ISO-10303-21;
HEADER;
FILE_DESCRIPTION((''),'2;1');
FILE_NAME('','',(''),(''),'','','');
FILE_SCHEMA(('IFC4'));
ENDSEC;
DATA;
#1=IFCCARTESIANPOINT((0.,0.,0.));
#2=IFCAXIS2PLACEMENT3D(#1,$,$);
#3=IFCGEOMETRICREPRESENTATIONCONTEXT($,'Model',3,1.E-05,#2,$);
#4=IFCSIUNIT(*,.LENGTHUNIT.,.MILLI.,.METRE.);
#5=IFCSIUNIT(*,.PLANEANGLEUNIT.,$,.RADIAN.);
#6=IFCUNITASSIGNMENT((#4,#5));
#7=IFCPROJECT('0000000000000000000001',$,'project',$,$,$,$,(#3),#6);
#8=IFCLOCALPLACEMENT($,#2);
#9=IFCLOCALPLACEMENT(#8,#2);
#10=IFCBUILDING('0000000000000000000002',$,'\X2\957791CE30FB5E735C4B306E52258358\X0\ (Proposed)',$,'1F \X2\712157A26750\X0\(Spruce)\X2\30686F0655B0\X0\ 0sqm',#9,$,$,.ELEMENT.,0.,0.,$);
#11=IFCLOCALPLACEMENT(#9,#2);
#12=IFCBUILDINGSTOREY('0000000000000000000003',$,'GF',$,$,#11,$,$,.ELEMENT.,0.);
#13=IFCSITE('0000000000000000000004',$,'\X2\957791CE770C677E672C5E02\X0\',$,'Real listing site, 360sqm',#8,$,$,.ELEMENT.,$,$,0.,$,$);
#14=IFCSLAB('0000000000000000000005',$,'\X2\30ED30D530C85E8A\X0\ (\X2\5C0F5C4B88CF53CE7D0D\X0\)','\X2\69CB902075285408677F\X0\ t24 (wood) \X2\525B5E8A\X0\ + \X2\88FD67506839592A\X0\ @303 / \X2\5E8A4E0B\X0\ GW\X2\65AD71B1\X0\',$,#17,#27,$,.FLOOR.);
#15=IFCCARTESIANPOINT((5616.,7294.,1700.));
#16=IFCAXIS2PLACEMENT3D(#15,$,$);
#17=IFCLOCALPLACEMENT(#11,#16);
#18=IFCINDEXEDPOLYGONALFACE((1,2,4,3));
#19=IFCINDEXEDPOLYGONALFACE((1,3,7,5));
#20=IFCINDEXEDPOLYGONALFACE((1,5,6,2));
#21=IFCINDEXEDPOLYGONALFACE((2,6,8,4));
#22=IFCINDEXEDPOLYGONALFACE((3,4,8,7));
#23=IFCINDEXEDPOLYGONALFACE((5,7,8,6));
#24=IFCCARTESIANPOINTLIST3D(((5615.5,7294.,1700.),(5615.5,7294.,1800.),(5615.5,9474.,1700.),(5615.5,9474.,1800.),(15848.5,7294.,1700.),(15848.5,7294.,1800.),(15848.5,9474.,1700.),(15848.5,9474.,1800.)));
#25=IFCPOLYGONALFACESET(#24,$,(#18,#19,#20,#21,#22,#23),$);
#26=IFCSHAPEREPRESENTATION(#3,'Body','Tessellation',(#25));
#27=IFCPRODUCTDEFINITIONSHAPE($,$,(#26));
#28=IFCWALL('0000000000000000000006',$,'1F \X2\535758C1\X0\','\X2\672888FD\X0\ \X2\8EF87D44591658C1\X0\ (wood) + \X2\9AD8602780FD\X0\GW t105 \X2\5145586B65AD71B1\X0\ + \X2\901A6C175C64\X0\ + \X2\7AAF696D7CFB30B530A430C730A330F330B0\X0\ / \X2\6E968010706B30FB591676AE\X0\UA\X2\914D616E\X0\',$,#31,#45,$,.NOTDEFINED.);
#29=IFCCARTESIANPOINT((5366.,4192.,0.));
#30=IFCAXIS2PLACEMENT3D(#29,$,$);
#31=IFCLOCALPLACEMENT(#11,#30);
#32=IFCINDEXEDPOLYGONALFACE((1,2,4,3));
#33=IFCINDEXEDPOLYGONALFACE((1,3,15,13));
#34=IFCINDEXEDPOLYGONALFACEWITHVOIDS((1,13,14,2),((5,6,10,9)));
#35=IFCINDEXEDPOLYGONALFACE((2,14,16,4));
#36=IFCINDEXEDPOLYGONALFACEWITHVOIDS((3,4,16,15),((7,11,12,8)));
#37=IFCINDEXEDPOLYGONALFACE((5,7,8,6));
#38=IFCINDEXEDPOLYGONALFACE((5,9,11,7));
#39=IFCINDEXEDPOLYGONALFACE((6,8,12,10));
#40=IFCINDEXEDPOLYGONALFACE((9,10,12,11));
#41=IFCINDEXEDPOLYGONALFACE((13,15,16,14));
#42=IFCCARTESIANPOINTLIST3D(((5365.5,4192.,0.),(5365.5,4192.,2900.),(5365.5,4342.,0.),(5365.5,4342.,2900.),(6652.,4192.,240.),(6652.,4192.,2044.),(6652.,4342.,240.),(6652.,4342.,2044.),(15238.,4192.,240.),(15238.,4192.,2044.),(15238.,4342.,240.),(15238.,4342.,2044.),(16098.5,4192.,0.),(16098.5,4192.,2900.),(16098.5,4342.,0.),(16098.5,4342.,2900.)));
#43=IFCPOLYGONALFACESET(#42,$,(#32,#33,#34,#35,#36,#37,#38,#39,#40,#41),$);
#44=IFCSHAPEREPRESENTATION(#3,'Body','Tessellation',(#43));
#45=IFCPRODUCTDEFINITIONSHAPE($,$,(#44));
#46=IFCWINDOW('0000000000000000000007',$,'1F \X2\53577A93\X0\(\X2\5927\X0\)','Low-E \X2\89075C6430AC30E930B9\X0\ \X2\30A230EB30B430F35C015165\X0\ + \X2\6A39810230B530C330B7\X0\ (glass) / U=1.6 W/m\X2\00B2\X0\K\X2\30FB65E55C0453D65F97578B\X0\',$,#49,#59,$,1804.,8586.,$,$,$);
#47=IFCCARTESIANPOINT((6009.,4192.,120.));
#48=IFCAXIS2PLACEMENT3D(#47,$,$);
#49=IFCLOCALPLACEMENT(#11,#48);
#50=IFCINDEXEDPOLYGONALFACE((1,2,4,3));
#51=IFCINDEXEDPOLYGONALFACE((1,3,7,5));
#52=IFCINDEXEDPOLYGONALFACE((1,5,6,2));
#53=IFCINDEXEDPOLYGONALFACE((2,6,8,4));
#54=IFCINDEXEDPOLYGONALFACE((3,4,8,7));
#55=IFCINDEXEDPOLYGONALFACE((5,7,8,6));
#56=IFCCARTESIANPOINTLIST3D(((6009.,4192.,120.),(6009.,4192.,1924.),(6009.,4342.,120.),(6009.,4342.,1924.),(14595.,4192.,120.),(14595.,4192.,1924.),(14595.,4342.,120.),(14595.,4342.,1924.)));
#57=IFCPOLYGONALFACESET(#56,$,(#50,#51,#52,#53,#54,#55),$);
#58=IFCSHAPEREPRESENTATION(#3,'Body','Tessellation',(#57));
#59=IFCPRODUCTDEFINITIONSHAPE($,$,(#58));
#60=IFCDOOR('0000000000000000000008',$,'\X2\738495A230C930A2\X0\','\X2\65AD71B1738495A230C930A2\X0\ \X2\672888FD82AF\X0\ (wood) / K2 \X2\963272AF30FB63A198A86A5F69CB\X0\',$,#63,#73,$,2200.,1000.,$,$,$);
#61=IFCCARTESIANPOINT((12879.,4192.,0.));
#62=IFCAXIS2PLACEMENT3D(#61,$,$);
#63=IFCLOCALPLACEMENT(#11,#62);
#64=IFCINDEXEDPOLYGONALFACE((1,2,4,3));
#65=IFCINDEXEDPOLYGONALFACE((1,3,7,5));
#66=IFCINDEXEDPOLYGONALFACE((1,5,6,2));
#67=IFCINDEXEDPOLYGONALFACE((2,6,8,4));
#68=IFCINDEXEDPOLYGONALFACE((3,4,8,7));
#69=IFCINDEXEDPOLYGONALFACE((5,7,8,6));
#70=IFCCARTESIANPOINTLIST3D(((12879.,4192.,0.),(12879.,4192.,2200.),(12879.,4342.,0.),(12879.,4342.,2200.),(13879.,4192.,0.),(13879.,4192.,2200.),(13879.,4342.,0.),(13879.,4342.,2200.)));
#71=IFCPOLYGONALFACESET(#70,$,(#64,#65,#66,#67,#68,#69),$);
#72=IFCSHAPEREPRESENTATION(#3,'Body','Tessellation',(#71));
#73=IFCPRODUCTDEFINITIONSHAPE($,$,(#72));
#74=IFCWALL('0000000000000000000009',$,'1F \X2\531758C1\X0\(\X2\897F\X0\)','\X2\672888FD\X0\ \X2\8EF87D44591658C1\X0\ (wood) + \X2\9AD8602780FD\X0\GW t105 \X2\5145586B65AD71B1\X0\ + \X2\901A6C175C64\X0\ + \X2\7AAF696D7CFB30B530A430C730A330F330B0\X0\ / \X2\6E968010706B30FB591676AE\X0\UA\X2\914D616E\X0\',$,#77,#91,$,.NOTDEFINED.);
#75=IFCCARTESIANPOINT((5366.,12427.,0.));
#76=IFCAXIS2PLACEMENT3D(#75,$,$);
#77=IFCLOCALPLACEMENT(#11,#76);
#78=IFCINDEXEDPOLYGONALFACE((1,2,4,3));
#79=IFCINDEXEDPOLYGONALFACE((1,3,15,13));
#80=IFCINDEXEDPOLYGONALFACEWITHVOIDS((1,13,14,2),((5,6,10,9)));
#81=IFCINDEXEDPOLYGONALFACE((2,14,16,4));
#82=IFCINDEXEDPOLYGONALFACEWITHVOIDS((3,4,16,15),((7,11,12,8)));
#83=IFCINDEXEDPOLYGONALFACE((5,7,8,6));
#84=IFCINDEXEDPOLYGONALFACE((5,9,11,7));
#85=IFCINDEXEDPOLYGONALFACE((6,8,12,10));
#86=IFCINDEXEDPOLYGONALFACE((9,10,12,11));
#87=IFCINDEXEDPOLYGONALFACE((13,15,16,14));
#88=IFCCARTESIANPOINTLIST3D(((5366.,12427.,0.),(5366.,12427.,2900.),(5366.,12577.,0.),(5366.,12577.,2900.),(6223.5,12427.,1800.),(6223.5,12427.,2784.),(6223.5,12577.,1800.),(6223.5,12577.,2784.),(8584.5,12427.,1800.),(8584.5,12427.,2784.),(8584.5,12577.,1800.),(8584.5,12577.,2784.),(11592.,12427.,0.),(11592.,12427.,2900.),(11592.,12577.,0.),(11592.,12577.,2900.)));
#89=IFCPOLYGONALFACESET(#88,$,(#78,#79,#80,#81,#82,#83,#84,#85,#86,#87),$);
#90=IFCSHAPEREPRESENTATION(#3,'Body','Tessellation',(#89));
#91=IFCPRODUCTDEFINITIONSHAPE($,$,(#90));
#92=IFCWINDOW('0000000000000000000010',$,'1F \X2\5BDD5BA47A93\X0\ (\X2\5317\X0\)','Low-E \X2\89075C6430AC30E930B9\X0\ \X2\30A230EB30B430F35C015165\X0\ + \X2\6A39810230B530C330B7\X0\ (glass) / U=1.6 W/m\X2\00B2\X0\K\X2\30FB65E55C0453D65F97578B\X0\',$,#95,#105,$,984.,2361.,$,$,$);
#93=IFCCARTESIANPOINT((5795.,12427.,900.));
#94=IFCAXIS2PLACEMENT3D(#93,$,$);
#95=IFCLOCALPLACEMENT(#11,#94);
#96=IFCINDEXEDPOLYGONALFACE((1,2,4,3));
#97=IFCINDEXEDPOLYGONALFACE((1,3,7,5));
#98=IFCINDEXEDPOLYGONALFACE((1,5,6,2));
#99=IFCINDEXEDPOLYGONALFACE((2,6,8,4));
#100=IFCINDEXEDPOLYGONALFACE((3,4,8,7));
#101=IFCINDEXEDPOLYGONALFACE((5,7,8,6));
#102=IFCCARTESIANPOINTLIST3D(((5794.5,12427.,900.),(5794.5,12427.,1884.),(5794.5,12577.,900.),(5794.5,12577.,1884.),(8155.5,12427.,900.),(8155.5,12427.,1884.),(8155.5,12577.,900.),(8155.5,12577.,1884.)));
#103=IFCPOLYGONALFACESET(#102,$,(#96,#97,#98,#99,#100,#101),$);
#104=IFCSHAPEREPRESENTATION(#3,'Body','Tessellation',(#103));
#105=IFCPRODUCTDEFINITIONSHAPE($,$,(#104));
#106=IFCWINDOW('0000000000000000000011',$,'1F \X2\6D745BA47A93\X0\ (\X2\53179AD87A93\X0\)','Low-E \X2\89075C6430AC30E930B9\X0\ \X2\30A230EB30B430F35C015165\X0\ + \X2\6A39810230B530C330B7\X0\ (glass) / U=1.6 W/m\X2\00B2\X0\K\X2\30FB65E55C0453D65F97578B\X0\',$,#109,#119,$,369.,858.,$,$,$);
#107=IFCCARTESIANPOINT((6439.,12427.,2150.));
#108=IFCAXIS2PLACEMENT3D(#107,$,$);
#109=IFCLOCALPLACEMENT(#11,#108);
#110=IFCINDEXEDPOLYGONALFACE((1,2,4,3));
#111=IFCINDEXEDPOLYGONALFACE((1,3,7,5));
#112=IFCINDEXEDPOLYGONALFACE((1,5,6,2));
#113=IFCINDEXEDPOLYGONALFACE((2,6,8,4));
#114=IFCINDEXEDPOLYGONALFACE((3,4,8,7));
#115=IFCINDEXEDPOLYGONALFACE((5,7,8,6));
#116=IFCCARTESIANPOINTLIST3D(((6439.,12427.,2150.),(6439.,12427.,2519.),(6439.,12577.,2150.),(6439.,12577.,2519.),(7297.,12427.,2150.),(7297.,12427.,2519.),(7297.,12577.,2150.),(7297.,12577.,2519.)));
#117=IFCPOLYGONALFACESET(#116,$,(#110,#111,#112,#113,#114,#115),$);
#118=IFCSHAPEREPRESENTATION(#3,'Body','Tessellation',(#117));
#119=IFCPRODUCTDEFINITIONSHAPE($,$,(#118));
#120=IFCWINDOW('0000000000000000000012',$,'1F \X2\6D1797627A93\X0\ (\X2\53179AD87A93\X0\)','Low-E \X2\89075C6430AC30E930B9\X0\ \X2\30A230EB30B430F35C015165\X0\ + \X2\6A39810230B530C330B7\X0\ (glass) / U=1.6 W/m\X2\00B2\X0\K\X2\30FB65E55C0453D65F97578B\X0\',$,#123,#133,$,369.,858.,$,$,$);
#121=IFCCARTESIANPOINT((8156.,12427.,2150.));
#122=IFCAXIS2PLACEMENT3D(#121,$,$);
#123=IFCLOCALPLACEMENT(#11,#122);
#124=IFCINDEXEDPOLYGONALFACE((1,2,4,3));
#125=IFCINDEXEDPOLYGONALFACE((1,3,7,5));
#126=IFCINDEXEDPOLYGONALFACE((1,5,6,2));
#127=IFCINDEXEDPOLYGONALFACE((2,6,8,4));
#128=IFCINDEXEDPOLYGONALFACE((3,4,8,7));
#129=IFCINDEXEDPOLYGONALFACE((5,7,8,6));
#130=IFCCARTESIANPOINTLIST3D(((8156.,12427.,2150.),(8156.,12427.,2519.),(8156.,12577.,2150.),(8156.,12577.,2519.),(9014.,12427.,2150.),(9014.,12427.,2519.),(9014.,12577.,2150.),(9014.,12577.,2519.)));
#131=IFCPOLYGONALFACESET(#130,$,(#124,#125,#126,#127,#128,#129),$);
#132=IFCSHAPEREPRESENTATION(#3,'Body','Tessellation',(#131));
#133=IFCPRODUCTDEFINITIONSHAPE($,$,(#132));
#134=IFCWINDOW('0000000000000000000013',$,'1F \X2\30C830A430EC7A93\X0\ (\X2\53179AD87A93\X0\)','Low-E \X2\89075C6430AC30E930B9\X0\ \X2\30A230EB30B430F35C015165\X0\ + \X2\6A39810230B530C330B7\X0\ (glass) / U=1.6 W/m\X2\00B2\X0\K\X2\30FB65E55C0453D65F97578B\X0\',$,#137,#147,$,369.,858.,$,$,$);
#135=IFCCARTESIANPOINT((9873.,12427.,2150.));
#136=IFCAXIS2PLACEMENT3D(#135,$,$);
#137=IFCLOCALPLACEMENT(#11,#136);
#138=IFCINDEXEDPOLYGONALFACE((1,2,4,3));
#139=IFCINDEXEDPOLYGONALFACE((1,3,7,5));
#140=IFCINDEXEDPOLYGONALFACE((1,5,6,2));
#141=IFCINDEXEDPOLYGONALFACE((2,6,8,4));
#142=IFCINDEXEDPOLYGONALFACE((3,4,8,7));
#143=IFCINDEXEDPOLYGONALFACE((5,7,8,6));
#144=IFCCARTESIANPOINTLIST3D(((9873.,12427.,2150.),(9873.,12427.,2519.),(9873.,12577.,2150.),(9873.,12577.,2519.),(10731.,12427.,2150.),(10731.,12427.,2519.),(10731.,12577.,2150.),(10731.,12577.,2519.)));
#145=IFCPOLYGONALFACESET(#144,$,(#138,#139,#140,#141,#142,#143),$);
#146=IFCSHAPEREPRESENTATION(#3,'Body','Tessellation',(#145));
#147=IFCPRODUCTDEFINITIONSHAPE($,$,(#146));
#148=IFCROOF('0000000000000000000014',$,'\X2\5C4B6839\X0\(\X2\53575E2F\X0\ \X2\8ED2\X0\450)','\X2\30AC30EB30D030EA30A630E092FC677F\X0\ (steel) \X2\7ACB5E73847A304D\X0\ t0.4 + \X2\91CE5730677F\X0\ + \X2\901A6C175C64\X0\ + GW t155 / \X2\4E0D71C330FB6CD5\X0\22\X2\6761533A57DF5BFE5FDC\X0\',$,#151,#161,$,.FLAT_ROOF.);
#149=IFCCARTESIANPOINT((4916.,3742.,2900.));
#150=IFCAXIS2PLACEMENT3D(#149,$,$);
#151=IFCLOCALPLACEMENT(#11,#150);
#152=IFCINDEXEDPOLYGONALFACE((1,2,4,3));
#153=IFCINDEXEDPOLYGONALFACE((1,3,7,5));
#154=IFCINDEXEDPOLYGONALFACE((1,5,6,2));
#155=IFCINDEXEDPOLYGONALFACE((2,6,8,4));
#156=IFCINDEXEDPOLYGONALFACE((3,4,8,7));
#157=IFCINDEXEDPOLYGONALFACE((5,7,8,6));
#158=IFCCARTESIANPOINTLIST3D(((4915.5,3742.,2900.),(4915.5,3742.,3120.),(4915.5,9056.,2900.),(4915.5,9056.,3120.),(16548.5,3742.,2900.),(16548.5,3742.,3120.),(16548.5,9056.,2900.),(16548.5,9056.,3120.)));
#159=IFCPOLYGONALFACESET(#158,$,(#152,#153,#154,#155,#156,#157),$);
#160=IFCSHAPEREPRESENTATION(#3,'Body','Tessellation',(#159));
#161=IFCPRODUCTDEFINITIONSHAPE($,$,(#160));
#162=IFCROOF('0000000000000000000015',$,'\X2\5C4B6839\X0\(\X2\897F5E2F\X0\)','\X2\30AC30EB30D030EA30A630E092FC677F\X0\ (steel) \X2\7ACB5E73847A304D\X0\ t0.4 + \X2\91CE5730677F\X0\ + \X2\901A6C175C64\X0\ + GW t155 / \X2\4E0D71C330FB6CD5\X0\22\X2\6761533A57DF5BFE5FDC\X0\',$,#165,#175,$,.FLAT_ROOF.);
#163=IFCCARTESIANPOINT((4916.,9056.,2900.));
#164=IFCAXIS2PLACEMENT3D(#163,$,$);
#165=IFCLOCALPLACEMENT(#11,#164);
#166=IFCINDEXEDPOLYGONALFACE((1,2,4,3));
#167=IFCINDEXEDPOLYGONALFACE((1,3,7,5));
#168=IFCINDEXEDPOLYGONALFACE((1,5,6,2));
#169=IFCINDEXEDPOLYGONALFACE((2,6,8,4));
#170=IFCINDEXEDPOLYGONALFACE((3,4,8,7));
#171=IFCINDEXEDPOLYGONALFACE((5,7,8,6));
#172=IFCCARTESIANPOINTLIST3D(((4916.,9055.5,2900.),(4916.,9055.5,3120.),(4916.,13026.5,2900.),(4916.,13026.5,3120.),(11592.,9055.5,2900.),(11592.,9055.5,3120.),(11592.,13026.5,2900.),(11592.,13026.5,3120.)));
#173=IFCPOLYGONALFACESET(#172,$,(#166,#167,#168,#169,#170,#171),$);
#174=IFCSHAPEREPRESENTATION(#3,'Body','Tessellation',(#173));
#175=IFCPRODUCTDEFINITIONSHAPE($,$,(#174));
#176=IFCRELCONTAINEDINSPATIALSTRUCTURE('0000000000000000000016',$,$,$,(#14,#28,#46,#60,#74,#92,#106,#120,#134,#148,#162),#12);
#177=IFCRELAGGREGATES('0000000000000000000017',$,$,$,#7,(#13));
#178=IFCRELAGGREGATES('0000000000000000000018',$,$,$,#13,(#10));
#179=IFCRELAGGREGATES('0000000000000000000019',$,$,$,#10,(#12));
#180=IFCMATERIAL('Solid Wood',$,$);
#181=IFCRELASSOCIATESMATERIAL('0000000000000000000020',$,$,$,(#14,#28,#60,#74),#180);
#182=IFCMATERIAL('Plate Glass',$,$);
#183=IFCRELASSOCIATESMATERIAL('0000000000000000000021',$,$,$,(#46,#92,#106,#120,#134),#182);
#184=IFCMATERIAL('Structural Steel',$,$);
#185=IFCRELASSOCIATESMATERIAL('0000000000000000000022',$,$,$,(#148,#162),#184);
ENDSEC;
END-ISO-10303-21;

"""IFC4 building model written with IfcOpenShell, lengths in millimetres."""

from ifc_helpers import new_model, si_unit, frame, frame_2d, origin, place, context, project, spatial, rectangle, extrude, material, element, fill, save


model = new_model("IFC4")

# Units and contexts
model_context = context("Model", 3, precision=1e-05, world=origin())
ifc_project = project(units=[si_unit("LENGTHUNIT", "METRE", prefix="MILLI"), si_unit("PLANEANGLEUNIT", "RADIAN")], contexts=[model_context])

# Site, building, storey
site_placement = place(None, origin())
site = spatial("IfcSite", under=ifc_project, at=site_placement, Name="長野県松本市", ObjectType="Real listing site, 360sqm", CompositionType="ELEMENT", RefElevation=0.0)
building_placement = place(site_placement, origin())
building = spatial("IfcBuilding", under=site, at=building_placement, Name="長野・平屋の別荘 (Proposed)", ObjectType="1F 無垢材(Spruce)と漆喰 0sqm", CompositionType="ELEMENT", ElevationOfRefHeight=0.0, ElevationOfTerrain=0.0)
storey_placement = place(building_placement, origin())
storey = spatial("IfcBuildingStorey", under=building, at=storey_placement, Name="GF", CompositionType="ELEMENT", Elevation=0.0)

# Slab
ifc_material_1 = material(Name="Solid Wood")
slab_1_placement = place(storey_placement, frame((5616.0, 7294.0, 1700.0)))
element("IfcSlab", 1, at=slab_1_placement, inside=storey, material=ifc_material_1, Name="ロフト床 (小屋裏収納)", Description="構造用合板 t24 (wood) 剛床 + 製材根太 @303 / 床下 GW断熱", PredefinedType="FLOOR", context=model_context, shape_type="SweptSolid", body=[
    extrude(rectangle(XDim=10233.0, YDim=2180.0, at=frame_2d((5116.0, 1090.0))), frame((5616.0, 7294.0, 1700.0)), (0.0, 0.0, 1.0), 100.0),
])

# Wall, openings, window, door
wall_1_placement = place(storey_placement, frame((5366.0, 4192.0, 0.0)))
wall_1 = element("IfcWall", 2, at=wall_1_placement, inside=storey, material=ifc_material_1, Name="1F 南壁", Description="木製 軸組外壁 (wood) + 高性能GW t105 充填断熱 + 通気層 + 窯業系サイディング / 準耐火・外皮UA配慮", PredefinedType="NOTDEFINED", context=model_context, shape_type="SweptSolid", body=[
    extrude(rectangle(XDim=10733.0, YDim=150.0, at=frame_2d((5366.0, 75.0))), frame((5366.0, 4192.0, 0.0)), (0.0, 0.0, 1.0), 2900.0),
])
opening_1_placement = place(storey_placement, frame((6009.0, 4192.0, 120.0)))
opening_1 = element("IfcOpeningElement", 3, at=opening_1_placement, cuts=wall_1, PredefinedType="NOTDEFINED", context=model_context, shape_type="SweptSolid", body=[
    extrude(rectangle(XDim=8586.0, YDim=150.0, at=frame_2d((4293.0, 75.0))), frame((6009.0, 4192.0, 120.0)), (0.0, 0.0, 1.0), 1804.0),
])
opening_2_placement = place(storey_placement, frame((12879.0, 4192.0, 0.0)))
opening_2 = element("IfcOpeningElement", 4, at=opening_2_placement, cuts=wall_1, PredefinedType="NOTDEFINED", context=model_context, shape_type="SweptSolid", body=[
    extrude(rectangle(XDim=1000.0, YDim=150.0, at=frame_2d((500.0, 75.0))), frame((12879.0, 4192.0, 0.0)), (0.0, 0.0, 1.0), 2200.0),
])
ifc_material_2 = material(Name="Plate Glass")
window_1_placement = place(storey_placement, frame((6009.0, 4192.0, 120.0)))
window_1 = element("IfcWindow", 5, at=window_1_placement, inside=storey, material=ifc_material_2, Name="1F 南窓(大)", Description="Low-E 複層ガラス アルゴン封入 + 樹脂サッシ (glass) / U=1.6 W/m²K・日射取得型", OverallHeight=1804.0, OverallWidth=8586.0, context=model_context, shape_type="SweptSolid", body=[
    extrude(rectangle(XDim=8586.0, YDim=150.0, at=frame_2d((4293.0, 75.0))), frame((6009.0, 4192.0, 120.0)), (0.0, 0.0, 1.0), 1804.0),
])
fill(opening_1, window_1)
door_1_placement = place(storey_placement, frame((12879.0, 4192.0, 0.0)))
door_1 = element("IfcDoor", 6, at=door_1_placement, inside=storey, material=ifc_material_1, Name="玄関ドア", Description="断熱玄関ドア 木製芯 (wood) / K2 防犯・採風機構", OverallHeight=2200.0, OverallWidth=1000.0, context=model_context, shape_type="SweptSolid", body=[
    extrude(rectangle(XDim=1000.0, YDim=150.0, at=frame_2d((500.0, 75.0))), frame((12879.0, 4192.0, 0.0)), (0.0, 0.0, 1.0), 2200.0),
])
fill(opening_2, door_1)

# Wall, openings, windows
wall_2_placement = place(storey_placement, frame((5366.0, 12427.0, 0.0)))
wall_2 = element("IfcWall", 7, at=wall_2_placement, inside=storey, material=ifc_material_1, Name="1F 北壁(西)", Description="木製 軸組外壁 (wood) + 高性能GW t105 充填断熱 + 通気層 + 窯業系サイディング / 準耐火・外皮UA配慮", PredefinedType="NOTDEFINED", context=model_context, shape_type="SweptSolid", body=[
    extrude(rectangle(XDim=6226.0, YDim=150.0, at=frame_2d((3113.0, 75.0))), frame((5366.0, 12427.0, 0.0)), (0.0, 0.0, 1.0), 2900.0),
])
opening_3_placement = place(storey_placement, frame((5795.0, 12427.0, 900.0)))
opening_3 = element("IfcOpeningElement", 8, at=opening_3_placement, cuts=wall_2, PredefinedType="NOTDEFINED", context=model_context, shape_type="SweptSolid", body=[
    extrude(rectangle(XDim=2361.0, YDim=150.0, at=frame_2d((1180.0, 75.0))), frame((5795.0, 12427.0, 900.0)), (0.0, 0.0, 1.0), 984.0),
])
opening_4_placement = place(storey_placement, frame((6439.0, 12427.0, 2150.0)))
opening_4 = element("IfcOpeningElement", 9, at=opening_4_placement, cuts=wall_2, PredefinedType="NOTDEFINED", context=model_context, shape_type="SweptSolid", body=[
    extrude(rectangle(XDim=858.0, YDim=150.0, at=frame_2d((429.0, 75.0))), frame((6439.0, 12427.0, 2150.0)), (0.0, 0.0, 1.0), 369.0),
])
opening_5_placement = place(storey_placement, frame((8156.0, 12427.0, 2150.0)))
opening_5 = element("IfcOpeningElement", 10, at=opening_5_placement, cuts=wall_2, PredefinedType="NOTDEFINED", context=model_context, shape_type="SweptSolid", body=[
    extrude(rectangle(XDim=858.0, YDim=150.0, at=frame_2d((429.0, 75.0))), frame((8156.0, 12427.0, 2150.0)), (0.0, 0.0, 1.0), 369.0),
])
opening_6_placement = place(storey_placement, frame((9873.0, 12427.0, 2150.0)))
opening_6 = element("IfcOpeningElement", 11, at=opening_6_placement, cuts=wall_2, PredefinedType="NOTDEFINED", context=model_context, shape_type="SweptSolid", body=[
    extrude(rectangle(XDim=858.0, YDim=150.0, at=frame_2d((429.0, 75.0))), frame((9873.0, 12427.0, 2150.0)), (0.0, 0.0, 1.0), 369.0),
])
window_2_placement = place(storey_placement, frame((5795.0, 12427.0, 900.0)))
window_2 = element("IfcWindow", 12, at=window_2_placement, inside=storey, material=ifc_material_2, Name="1F 寝室窓 (北)", Description="Low-E 複層ガラス アルゴン封入 + 樹脂サッシ (glass) / U=1.6 W/m²K・日射取得型", OverallHeight=984.0, OverallWidth=2361.0, context=model_context, shape_type="SweptSolid", body=[
    extrude(rectangle(XDim=2361.0, YDim=150.0, at=frame_2d((1180.0, 75.0))), frame((5795.0, 12427.0, 900.0)), (0.0, 0.0, 1.0), 984.0),
])
fill(opening_3, window_2)
window_3_placement = place(storey_placement, frame((6439.0, 12427.0, 2150.0)))
window_3 = element("IfcWindow", 13, at=window_3_placement, inside=storey, material=ifc_material_2, Name="1F 浴室窓 (北高窓)", Description="Low-E 複層ガラス アルゴン封入 + 樹脂サッシ (glass) / U=1.6 W/m²K・日射取得型", OverallHeight=369.0, OverallWidth=858.0, context=model_context, shape_type="SweptSolid", body=[
    extrude(rectangle(XDim=858.0, YDim=150.0, at=frame_2d((429.0, 75.0))), frame((6439.0, 12427.0, 2150.0)), (0.0, 0.0, 1.0), 369.0),
])
fill(opening_4, window_3)
window_4_placement = place(storey_placement, frame((8156.0, 12427.0, 2150.0)))
window_4 = element("IfcWindow", 14, at=window_4_placement, inside=storey, material=ifc_material_2, Name="1F 洗面窓 (北高窓)", Description="Low-E 複層ガラス アルゴン封入 + 樹脂サッシ (glass) / U=1.6 W/m²K・日射取得型", OverallHeight=369.0, OverallWidth=858.0, context=model_context, shape_type="SweptSolid", body=[
    extrude(rectangle(XDim=858.0, YDim=150.0, at=frame_2d((429.0, 75.0))), frame((8156.0, 12427.0, 2150.0)), (0.0, 0.0, 1.0), 369.0),
])
fill(opening_5, window_4)
window_5_placement = place(storey_placement, frame((9873.0, 12427.0, 2150.0)))
window_5 = element("IfcWindow", 15, at=window_5_placement, inside=storey, material=ifc_material_2, Name="1F トイレ窓 (北高窓)", Description="Low-E 複層ガラス アルゴン封入 + 樹脂サッシ (glass) / U=1.6 W/m²K・日射取得型", OverallHeight=369.0, OverallWidth=858.0, context=model_context, shape_type="SweptSolid", body=[
    extrude(rectangle(XDim=858.0, YDim=150.0, at=frame_2d((429.0, 75.0))), frame((9873.0, 12427.0, 2150.0)), (0.0, 0.0, 1.0), 369.0),
])
fill(opening_6, window_5)

# Roofs
ifc_material_3 = material(Name="Structural Steel")
roof_1_placement = place(storey_placement, frame((4916.0, 3742.0, 2900.0)))
element("IfcRoof", 16, at=roof_1_placement, inside=storey, material=ifc_material_3, Name="屋根(南帯 軒450)", Description="ガルバリウム鋼板 (steel) 立平葺き t0.4 + 野地板 + 通気層 + GW t155 / 不燃・法22条区域対応", PredefinedType="FLAT_ROOF", context=model_context, shape_type="SweptSolid", body=[
    extrude(rectangle(XDim=11633.0, YDim=5314.0, at=frame_2d((5816.0, 2657.0))), frame((4916.0, 3742.0, 2900.0)), (0.0, 0.0, 1.0), 220.0),
])
roof_2_placement = place(storey_placement, frame((4916.0, 9056.0, 2900.0)))
element("IfcRoof", 17, at=roof_2_placement, inside=storey, material=ifc_material_3, Name="屋根(西帯)", Description="ガルバリウム鋼板 (steel) 立平葺き t0.4 + 野地板 + 通気層 + GW t155 / 不燃・法22条区域対応", PredefinedType="FLAT_ROOF", context=model_context, shape_type="SweptSolid", body=[
    extrude(rectangle(XDim=6676.0, YDim=3971.0, at=frame_2d((3338.0, 1985.0))), frame((4916.0, 9056.0, 2900.0)), (0.0, 0.0, 1.0), 220.0),
])

save(model, "model.ifc")
